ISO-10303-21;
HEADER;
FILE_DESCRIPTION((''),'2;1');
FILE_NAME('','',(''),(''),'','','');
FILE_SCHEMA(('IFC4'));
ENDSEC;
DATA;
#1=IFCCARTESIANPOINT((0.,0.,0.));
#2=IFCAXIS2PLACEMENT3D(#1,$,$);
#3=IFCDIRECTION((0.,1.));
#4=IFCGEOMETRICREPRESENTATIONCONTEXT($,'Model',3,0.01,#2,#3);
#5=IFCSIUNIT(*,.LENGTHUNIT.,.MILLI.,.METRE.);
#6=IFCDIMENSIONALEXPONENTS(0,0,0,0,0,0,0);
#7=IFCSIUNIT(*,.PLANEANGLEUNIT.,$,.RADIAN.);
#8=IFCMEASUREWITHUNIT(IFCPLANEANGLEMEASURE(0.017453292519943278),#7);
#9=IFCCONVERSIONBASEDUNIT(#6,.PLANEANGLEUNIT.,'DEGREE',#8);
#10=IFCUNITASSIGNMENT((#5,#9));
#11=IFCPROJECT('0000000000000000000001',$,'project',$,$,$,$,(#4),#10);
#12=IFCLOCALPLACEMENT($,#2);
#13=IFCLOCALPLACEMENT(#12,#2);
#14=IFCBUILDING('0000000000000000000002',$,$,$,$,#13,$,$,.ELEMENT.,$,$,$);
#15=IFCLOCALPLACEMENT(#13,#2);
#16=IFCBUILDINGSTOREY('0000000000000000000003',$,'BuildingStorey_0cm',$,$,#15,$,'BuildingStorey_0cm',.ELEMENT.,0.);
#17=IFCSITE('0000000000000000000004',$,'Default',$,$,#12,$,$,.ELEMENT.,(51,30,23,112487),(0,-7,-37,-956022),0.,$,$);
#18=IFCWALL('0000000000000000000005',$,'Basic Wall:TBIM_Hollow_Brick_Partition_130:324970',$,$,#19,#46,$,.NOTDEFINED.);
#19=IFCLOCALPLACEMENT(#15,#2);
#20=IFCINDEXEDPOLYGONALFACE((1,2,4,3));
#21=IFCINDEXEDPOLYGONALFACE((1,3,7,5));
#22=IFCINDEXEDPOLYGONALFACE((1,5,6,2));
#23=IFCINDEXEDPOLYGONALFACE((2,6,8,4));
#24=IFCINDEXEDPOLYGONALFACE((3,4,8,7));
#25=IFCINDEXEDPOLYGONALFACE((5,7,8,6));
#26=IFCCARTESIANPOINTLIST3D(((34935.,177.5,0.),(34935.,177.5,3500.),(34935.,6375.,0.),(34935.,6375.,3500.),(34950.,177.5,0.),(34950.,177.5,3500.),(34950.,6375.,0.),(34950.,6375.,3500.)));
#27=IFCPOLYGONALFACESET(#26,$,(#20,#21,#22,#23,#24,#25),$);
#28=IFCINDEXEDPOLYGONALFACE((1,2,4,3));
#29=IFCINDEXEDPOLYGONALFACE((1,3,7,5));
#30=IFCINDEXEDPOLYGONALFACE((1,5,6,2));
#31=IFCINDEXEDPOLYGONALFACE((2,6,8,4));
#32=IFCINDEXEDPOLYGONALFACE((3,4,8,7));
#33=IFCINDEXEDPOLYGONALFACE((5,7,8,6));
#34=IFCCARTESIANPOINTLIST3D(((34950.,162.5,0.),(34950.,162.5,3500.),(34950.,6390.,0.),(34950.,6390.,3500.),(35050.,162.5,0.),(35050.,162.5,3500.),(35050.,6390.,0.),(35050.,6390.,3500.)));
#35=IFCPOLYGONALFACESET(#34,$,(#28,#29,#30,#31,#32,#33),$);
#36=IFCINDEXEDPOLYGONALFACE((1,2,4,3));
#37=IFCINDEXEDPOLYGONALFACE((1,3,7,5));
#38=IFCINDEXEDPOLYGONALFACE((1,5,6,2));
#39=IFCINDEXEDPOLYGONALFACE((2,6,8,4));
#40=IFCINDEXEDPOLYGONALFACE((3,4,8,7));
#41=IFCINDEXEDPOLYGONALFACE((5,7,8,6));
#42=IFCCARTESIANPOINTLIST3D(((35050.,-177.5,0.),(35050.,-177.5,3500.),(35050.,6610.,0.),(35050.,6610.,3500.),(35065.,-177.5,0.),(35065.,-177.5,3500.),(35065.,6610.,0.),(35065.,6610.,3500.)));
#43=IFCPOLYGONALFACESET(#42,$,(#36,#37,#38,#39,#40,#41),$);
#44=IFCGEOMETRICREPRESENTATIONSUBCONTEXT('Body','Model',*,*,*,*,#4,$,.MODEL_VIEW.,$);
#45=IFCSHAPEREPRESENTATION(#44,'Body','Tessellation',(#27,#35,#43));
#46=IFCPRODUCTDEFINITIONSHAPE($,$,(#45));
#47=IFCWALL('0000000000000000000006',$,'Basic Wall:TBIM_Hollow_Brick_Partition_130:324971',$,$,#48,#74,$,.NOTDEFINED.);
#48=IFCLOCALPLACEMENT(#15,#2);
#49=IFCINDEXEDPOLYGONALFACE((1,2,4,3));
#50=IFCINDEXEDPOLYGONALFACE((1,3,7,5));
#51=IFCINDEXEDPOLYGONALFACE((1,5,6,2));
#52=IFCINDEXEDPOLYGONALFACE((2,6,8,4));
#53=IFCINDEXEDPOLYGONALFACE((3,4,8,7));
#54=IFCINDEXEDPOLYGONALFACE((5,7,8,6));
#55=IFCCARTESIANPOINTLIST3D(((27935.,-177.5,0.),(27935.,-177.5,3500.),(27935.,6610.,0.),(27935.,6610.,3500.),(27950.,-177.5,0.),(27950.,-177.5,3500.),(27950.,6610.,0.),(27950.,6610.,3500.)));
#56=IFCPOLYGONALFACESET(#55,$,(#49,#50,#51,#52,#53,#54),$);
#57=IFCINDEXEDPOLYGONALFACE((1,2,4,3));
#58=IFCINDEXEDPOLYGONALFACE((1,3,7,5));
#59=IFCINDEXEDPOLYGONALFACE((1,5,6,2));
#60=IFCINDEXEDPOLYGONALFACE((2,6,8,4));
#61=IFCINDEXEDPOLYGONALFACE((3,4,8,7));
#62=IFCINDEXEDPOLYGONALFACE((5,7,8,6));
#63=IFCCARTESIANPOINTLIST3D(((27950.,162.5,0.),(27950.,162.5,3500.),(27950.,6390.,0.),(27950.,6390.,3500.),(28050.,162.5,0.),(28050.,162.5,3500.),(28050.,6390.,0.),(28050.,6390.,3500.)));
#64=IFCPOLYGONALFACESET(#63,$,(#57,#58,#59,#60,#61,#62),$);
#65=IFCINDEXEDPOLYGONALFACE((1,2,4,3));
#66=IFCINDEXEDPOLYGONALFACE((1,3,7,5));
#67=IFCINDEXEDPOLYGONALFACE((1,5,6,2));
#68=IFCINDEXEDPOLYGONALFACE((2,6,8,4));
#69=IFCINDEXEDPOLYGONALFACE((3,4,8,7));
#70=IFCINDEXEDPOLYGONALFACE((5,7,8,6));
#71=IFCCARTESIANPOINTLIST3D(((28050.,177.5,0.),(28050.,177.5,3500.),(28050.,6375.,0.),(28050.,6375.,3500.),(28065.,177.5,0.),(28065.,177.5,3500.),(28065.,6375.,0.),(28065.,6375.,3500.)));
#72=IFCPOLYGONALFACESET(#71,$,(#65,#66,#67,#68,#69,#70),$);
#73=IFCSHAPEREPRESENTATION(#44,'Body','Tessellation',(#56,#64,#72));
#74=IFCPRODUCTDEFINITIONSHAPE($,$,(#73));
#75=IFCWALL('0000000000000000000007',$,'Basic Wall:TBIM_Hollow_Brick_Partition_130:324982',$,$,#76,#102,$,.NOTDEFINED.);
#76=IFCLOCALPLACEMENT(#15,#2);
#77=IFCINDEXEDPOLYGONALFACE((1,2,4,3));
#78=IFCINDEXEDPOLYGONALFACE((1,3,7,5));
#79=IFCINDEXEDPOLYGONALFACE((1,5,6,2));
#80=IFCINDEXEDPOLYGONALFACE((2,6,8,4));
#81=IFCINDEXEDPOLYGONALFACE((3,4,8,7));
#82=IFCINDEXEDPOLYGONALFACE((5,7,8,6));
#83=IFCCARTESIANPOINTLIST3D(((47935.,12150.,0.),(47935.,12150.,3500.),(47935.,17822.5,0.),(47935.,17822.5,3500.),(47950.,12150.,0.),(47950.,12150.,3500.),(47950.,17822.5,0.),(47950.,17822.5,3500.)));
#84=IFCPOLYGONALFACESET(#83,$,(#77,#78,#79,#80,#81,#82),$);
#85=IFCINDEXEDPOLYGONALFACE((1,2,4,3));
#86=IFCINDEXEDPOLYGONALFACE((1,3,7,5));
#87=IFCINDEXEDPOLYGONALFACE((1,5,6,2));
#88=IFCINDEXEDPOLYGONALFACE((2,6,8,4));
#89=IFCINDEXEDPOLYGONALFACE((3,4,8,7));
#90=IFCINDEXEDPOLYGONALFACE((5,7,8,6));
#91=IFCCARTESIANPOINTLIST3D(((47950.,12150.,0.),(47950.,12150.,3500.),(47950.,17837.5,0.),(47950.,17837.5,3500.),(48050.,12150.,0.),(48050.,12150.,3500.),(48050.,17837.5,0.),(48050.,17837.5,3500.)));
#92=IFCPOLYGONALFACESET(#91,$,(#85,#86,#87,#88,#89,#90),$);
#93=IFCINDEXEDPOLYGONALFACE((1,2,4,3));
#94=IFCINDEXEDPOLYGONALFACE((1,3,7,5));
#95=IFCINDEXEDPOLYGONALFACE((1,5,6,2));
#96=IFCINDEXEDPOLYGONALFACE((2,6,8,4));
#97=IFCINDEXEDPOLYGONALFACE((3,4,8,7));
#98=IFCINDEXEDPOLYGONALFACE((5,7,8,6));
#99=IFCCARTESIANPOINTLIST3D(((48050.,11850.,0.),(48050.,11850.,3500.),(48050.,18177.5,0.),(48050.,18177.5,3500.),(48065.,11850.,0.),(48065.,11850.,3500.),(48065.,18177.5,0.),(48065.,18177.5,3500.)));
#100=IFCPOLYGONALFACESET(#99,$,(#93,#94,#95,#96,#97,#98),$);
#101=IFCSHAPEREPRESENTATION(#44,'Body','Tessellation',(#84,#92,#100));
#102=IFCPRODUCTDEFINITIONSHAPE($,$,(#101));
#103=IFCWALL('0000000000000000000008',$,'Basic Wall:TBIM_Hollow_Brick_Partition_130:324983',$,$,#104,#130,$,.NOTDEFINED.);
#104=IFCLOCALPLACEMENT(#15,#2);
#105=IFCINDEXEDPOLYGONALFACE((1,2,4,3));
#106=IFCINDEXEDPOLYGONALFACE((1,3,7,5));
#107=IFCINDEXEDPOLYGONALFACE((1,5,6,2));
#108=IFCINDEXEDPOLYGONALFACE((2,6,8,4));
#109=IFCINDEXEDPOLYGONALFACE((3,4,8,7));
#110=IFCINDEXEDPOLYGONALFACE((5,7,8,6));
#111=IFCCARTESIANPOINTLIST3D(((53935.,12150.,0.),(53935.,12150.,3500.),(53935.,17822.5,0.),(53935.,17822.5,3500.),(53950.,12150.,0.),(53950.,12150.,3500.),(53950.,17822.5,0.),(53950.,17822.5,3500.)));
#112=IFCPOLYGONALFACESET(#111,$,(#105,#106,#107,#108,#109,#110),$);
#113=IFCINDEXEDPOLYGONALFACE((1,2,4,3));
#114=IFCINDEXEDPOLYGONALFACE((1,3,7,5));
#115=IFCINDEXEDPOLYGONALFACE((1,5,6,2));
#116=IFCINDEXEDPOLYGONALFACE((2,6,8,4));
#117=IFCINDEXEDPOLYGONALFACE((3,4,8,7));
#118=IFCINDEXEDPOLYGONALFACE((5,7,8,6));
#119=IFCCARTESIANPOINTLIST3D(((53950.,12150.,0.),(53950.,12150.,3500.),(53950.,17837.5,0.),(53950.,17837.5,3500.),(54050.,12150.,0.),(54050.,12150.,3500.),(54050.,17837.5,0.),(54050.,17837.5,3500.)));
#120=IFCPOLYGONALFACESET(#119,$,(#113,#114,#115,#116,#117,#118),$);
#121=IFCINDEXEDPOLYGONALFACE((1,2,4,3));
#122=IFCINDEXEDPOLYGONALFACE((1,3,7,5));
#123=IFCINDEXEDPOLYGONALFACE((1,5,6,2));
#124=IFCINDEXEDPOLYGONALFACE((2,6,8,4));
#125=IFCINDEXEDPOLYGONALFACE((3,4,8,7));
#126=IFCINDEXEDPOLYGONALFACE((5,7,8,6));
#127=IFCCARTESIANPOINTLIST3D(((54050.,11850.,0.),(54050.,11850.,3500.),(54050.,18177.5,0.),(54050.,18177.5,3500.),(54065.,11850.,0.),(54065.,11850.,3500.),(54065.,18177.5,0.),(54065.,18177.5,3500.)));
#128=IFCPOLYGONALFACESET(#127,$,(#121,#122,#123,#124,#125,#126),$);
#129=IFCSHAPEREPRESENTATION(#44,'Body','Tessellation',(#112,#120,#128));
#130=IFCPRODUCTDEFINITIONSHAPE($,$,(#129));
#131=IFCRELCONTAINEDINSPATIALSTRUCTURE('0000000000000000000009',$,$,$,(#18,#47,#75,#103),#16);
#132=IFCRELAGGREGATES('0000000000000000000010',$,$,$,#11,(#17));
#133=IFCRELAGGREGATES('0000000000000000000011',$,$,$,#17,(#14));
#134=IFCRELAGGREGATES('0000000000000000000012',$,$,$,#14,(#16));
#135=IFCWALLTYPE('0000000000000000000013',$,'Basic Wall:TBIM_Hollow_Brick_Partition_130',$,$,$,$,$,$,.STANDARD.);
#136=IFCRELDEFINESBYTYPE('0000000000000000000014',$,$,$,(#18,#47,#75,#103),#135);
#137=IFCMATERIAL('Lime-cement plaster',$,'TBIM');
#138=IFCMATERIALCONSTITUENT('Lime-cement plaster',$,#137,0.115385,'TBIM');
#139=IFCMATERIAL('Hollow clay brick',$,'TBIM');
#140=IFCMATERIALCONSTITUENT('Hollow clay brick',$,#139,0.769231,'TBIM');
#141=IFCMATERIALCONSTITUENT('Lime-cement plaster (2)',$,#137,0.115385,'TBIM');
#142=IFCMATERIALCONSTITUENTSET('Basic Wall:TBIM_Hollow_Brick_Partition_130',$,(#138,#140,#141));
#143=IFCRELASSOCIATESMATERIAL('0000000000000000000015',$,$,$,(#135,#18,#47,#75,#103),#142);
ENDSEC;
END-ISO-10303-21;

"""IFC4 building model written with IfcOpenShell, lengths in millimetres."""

from ifc_helpers import new_model, entity, si_unit, converted_unit, direction, frame, origin, place, context, subcontext, project, spatial, indexed_curve, outline, extrude, material, constituent, constituent_set, type_object, element, save


model = new_model("IFC4")

# Units and contexts
model_context = context("Model", 3, precision=0.01, world=origin(), true_north=direction((0.0, 1.0)))
body_context = subcontext(model_context, "Body", "Model", "MODEL_VIEW")
ifc_project = project(units=[si_unit("LENGTHUNIT", "METRE", prefix="MILLI"), converted_unit("PLANEANGLEUNIT", "DEGREE", entity("IfcPlaneAngleMeasure", 0.017453292519943278), si_unit("PLANEANGLEUNIT", "RADIAN"), dimensions=[0, 0, 0, 0, 0, 0, 0])], contexts=[model_context])

# Site, building, storey
site_placement = place(None, origin())
site = spatial("IfcSite", under=ifc_project, at=site_placement, Name="Default", CompositionType="ELEMENT", RefLatitude=(51, 30, 23, 112487), RefLongitude=(0, -7, -37, -956022), RefElevation=0.0)
building_placement = place(site_placement, origin())
building = spatial("IfcBuilding", under=site, at=building_placement, CompositionType="ELEMENT")
storey_placement = place(building_placement, origin())
storey = spatial("IfcBuildingStorey", under=building, at=storey_placement, Name="BuildingStorey_0cm", LongName="BuildingStorey_0cm", CompositionType="ELEMENT", Elevation=0.0)

# Shared definitions
ifc_material_1 = material(Name="Lime-cement plaster", Category="TBIM")

# Walls
ifc_constituent_1 = constituent(ifc_material_1, Name="Lime-cement plaster", Category="TBIM", fraction=0.115385)
ifc_material_2 = material(Name="Hollow clay brick", Category="TBIM")
ifc_constituent_2 = constituent(ifc_material_2, Name="Hollow clay brick", Category="TBIM", fraction=0.769231)
ifc_constituent_3 = constituent(ifc_material_1, Name="Lime-cement plaster (2)", Category="TBIM", fraction=0.115385)
ifc_constituent_set_1 = constituent_set(constituents=[ifc_constituent_1, ifc_constituent_2, ifc_constituent_3], Name="Basic Wall:TBIM_Hollow_Brick_Partition_130")
wall_type_1 = type_object("IfcWallType", Name="Basic Wall:TBIM_Hollow_Brick_Partition_130", PredefinedType="STANDARD", material=ifc_constituent_set_1)
wall_1_placement = place(storey_placement, frame((35000.0, 177.5, 0.0), z_axis=(0.0, 0.0, 1.0), x_axis=(0.0, 1.0, 0.0)))
element("IfcWall", 1, at=wall_1_placement, inside=storey, type_object=wall_type_1, material=ifc_constituent_set_1, Name="Basic Wall:TBIM_Hollow_Brick_Partition_130:324970", PredefinedType="NOTDEFINED", context=body_context, shape_type="SweptSolid", body=[
    extrude(outline(indexed_curve([(-7.5, -3098.8), (7.5, -3098.8), (7.5, 3098.8), (-7.5, 3098.8), (-7.5, -3098.8)], self_intersect=False)), frame((3098.8, 57.5, 0.0), z_axis=(0.0, 0.0, 1.0), x_axis=(0.0, -1.0, 0.0)), (0.0, 0.0, 1.0), 3500.0),
    extrude(outline(indexed_curve([(-3113.8, -50.0), (3113.8, -50.0), (3113.8, 50.0), (-3113.8, 50.0), (-3113.8, -50.0)], self_intersect=False)), frame((3098.8, 0.0, 0.0)), (0.0, 0.0, 1.0), 3500.0),
    extrude(outline(indexed_curve([(-7.5, -3393.8), (7.5, -3393.8), (7.5, 3393.7), (-7.5, 3393.7), (-7.5, -3393.8)], self_intersect=False)), frame((3038.7, -57.5, 0.0), z_axis=(0.0, 0.0, 1.0), x_axis=(0.0, 1.0, 0.0)), (0.0, 0.0, 1.0), 3500.0),
])
wall_2_placement = place(storey_placement, frame((28000.0, 177.5, 0.0), z_axis=(0.0, 0.0, 1.0), x_axis=(0.0, 1.0, 0.0)))
element("IfcWall", 2, at=wall_2_placement, inside=storey, type_object=wall_type_1, material=ifc_constituent_set_1, Name="Basic Wall:TBIM_Hollow_Brick_Partition_130:324971", PredefinedType="NOTDEFINED", context=body_context, shape_type="SweptSolid", body=[
    extrude(outline(indexed_curve([(-7.5, -3393.7), (7.5, -3393.7), (7.5, 3393.7), (-7.5, 3393.7), (-7.5, -3393.7)], self_intersect=False)), frame((3038.8, 57.5, 0.0), z_axis=(0.0, 0.0, 1.0), x_axis=(0.0, -1.0, 0.0)), (0.0, 0.0, 1.0), 3500.0),
    extrude(outline(indexed_curve([(-3113.8, -50.0), (3113.8, -50.0), (3113.8, 50.0), (-3113.8, 50.0), (-3113.8, -50.0)], self_intersect=False)), frame((3098.8, 0.0, 0.0)), (0.0, 0.0, 1.0), 3500.0),
    extrude(outline(indexed_curve([(-7.5, -3098.7), (7.5, -3098.7), (7.5, 3098.8), (-7.5, 3098.8), (-7.5, -3098.7)], self_intersect=False)), frame((3098.8, -57.5, 0.0), z_axis=(0.0, 0.0, 1.0), x_axis=(0.0, 1.0, 0.0)), (0.0, 0.0, 1.0), 3500.0),
])
wall_3_placement = place(storey_placement, frame((48000.0, 12150.0, 0.0), z_axis=(0.0, 0.0, 1.0), x_axis=(0.0, 1.0, 0.0)))
element("IfcWall", 3, at=wall_3_placement, inside=storey, type_object=wall_type_1, material=ifc_constituent_set_1, Name="Basic Wall:TBIM_Hollow_Brick_Partition_130:324982", PredefinedType="NOTDEFINED", context=body_context, shape_type="SweptSolid", body=[
    extrude(outline(indexed_curve([(-7.5, -2836.3), (7.5, -2836.3), (7.5, 2836.2), (-7.5, 2836.2), (-7.5, -2836.3)], self_intersect=False)), frame((2836.3, 57.5, 0.0), z_axis=(0.0, 0.0, 1.0), x_axis=(0.0, -1.0, 0.0)), (0.0, 0.0, 1.0), 3500.0),
    extrude(outline(indexed_curve([(-2843.7, -50.0), (2843.8, -50.0), (2843.8, 50.0), (-2843.7, 50.0), (-2843.7, -50.0)], self_intersect=False)), frame((2843.7, 0.0, 0.0)), (0.0, 0.0, 1.0), 3500.0),
    extrude(outline(indexed_curve([(-7.5, -3163.8), (7.5, -3163.8), (7.5, 3163.8), (-7.5, 3163.8), (-7.5, -3163.8)], self_intersect=False)), frame((2863.7, -57.5, 0.0), z_axis=(0.0, 0.0, 1.0), x_axis=(0.0, 1.0, 0.0)), (0.0, 0.0, 1.0), 3500.0),
])
wall_4_placement = place(storey_placement, frame((54000.0, 12150.0, 0.0), z_axis=(0.0, 0.0, 1.0), x_axis=(0.0, 1.0, 0.0)))
element("IfcWall", 4, at=wall_4_placement, inside=storey, type_object=wall_type_1, material=ifc_constituent_set_1, Name="Basic Wall:TBIM_Hollow_Brick_Partition_130:324983", PredefinedType="NOTDEFINED", context=body_context, shape_type="SweptSolid", body=[
    extrude(outline(indexed_curve([(-7.5, -2836.3), (7.5, -2836.3), (7.5, 2836.2), (-7.5, 2836.2), (-7.5, -2836.3)], self_intersect=False)), frame((2836.3, 57.5, 0.0), z_axis=(0.0, 0.0, 1.0), x_axis=(0.0, -1.0, 0.0)), (0.0, 0.0, 1.0), 3500.0),
    extrude(outline(indexed_curve([(-2843.7, -50.0), (2843.8, -50.0), (2843.8, 50.0), (-2843.7, 50.0), (-2843.7, -50.0)], self_intersect=False)), frame((2843.7, 0.0, 0.0)), (0.0, 0.0, 1.0), 3500.0),
    extrude(outline(indexed_curve([(-7.5, -3163.8), (7.5, -3163.8), (7.5, 3163.8), (-7.5, 3163.8), (-7.5, -3163.8)], self_intersect=False)), frame((2863.7, -57.5, 0.0), z_axis=(0.0, 0.0, 1.0), x_axis=(0.0, 1.0, 0.0)), (0.0, 0.0, 1.0), 3500.0),
])

save(model, "model.ifc")
